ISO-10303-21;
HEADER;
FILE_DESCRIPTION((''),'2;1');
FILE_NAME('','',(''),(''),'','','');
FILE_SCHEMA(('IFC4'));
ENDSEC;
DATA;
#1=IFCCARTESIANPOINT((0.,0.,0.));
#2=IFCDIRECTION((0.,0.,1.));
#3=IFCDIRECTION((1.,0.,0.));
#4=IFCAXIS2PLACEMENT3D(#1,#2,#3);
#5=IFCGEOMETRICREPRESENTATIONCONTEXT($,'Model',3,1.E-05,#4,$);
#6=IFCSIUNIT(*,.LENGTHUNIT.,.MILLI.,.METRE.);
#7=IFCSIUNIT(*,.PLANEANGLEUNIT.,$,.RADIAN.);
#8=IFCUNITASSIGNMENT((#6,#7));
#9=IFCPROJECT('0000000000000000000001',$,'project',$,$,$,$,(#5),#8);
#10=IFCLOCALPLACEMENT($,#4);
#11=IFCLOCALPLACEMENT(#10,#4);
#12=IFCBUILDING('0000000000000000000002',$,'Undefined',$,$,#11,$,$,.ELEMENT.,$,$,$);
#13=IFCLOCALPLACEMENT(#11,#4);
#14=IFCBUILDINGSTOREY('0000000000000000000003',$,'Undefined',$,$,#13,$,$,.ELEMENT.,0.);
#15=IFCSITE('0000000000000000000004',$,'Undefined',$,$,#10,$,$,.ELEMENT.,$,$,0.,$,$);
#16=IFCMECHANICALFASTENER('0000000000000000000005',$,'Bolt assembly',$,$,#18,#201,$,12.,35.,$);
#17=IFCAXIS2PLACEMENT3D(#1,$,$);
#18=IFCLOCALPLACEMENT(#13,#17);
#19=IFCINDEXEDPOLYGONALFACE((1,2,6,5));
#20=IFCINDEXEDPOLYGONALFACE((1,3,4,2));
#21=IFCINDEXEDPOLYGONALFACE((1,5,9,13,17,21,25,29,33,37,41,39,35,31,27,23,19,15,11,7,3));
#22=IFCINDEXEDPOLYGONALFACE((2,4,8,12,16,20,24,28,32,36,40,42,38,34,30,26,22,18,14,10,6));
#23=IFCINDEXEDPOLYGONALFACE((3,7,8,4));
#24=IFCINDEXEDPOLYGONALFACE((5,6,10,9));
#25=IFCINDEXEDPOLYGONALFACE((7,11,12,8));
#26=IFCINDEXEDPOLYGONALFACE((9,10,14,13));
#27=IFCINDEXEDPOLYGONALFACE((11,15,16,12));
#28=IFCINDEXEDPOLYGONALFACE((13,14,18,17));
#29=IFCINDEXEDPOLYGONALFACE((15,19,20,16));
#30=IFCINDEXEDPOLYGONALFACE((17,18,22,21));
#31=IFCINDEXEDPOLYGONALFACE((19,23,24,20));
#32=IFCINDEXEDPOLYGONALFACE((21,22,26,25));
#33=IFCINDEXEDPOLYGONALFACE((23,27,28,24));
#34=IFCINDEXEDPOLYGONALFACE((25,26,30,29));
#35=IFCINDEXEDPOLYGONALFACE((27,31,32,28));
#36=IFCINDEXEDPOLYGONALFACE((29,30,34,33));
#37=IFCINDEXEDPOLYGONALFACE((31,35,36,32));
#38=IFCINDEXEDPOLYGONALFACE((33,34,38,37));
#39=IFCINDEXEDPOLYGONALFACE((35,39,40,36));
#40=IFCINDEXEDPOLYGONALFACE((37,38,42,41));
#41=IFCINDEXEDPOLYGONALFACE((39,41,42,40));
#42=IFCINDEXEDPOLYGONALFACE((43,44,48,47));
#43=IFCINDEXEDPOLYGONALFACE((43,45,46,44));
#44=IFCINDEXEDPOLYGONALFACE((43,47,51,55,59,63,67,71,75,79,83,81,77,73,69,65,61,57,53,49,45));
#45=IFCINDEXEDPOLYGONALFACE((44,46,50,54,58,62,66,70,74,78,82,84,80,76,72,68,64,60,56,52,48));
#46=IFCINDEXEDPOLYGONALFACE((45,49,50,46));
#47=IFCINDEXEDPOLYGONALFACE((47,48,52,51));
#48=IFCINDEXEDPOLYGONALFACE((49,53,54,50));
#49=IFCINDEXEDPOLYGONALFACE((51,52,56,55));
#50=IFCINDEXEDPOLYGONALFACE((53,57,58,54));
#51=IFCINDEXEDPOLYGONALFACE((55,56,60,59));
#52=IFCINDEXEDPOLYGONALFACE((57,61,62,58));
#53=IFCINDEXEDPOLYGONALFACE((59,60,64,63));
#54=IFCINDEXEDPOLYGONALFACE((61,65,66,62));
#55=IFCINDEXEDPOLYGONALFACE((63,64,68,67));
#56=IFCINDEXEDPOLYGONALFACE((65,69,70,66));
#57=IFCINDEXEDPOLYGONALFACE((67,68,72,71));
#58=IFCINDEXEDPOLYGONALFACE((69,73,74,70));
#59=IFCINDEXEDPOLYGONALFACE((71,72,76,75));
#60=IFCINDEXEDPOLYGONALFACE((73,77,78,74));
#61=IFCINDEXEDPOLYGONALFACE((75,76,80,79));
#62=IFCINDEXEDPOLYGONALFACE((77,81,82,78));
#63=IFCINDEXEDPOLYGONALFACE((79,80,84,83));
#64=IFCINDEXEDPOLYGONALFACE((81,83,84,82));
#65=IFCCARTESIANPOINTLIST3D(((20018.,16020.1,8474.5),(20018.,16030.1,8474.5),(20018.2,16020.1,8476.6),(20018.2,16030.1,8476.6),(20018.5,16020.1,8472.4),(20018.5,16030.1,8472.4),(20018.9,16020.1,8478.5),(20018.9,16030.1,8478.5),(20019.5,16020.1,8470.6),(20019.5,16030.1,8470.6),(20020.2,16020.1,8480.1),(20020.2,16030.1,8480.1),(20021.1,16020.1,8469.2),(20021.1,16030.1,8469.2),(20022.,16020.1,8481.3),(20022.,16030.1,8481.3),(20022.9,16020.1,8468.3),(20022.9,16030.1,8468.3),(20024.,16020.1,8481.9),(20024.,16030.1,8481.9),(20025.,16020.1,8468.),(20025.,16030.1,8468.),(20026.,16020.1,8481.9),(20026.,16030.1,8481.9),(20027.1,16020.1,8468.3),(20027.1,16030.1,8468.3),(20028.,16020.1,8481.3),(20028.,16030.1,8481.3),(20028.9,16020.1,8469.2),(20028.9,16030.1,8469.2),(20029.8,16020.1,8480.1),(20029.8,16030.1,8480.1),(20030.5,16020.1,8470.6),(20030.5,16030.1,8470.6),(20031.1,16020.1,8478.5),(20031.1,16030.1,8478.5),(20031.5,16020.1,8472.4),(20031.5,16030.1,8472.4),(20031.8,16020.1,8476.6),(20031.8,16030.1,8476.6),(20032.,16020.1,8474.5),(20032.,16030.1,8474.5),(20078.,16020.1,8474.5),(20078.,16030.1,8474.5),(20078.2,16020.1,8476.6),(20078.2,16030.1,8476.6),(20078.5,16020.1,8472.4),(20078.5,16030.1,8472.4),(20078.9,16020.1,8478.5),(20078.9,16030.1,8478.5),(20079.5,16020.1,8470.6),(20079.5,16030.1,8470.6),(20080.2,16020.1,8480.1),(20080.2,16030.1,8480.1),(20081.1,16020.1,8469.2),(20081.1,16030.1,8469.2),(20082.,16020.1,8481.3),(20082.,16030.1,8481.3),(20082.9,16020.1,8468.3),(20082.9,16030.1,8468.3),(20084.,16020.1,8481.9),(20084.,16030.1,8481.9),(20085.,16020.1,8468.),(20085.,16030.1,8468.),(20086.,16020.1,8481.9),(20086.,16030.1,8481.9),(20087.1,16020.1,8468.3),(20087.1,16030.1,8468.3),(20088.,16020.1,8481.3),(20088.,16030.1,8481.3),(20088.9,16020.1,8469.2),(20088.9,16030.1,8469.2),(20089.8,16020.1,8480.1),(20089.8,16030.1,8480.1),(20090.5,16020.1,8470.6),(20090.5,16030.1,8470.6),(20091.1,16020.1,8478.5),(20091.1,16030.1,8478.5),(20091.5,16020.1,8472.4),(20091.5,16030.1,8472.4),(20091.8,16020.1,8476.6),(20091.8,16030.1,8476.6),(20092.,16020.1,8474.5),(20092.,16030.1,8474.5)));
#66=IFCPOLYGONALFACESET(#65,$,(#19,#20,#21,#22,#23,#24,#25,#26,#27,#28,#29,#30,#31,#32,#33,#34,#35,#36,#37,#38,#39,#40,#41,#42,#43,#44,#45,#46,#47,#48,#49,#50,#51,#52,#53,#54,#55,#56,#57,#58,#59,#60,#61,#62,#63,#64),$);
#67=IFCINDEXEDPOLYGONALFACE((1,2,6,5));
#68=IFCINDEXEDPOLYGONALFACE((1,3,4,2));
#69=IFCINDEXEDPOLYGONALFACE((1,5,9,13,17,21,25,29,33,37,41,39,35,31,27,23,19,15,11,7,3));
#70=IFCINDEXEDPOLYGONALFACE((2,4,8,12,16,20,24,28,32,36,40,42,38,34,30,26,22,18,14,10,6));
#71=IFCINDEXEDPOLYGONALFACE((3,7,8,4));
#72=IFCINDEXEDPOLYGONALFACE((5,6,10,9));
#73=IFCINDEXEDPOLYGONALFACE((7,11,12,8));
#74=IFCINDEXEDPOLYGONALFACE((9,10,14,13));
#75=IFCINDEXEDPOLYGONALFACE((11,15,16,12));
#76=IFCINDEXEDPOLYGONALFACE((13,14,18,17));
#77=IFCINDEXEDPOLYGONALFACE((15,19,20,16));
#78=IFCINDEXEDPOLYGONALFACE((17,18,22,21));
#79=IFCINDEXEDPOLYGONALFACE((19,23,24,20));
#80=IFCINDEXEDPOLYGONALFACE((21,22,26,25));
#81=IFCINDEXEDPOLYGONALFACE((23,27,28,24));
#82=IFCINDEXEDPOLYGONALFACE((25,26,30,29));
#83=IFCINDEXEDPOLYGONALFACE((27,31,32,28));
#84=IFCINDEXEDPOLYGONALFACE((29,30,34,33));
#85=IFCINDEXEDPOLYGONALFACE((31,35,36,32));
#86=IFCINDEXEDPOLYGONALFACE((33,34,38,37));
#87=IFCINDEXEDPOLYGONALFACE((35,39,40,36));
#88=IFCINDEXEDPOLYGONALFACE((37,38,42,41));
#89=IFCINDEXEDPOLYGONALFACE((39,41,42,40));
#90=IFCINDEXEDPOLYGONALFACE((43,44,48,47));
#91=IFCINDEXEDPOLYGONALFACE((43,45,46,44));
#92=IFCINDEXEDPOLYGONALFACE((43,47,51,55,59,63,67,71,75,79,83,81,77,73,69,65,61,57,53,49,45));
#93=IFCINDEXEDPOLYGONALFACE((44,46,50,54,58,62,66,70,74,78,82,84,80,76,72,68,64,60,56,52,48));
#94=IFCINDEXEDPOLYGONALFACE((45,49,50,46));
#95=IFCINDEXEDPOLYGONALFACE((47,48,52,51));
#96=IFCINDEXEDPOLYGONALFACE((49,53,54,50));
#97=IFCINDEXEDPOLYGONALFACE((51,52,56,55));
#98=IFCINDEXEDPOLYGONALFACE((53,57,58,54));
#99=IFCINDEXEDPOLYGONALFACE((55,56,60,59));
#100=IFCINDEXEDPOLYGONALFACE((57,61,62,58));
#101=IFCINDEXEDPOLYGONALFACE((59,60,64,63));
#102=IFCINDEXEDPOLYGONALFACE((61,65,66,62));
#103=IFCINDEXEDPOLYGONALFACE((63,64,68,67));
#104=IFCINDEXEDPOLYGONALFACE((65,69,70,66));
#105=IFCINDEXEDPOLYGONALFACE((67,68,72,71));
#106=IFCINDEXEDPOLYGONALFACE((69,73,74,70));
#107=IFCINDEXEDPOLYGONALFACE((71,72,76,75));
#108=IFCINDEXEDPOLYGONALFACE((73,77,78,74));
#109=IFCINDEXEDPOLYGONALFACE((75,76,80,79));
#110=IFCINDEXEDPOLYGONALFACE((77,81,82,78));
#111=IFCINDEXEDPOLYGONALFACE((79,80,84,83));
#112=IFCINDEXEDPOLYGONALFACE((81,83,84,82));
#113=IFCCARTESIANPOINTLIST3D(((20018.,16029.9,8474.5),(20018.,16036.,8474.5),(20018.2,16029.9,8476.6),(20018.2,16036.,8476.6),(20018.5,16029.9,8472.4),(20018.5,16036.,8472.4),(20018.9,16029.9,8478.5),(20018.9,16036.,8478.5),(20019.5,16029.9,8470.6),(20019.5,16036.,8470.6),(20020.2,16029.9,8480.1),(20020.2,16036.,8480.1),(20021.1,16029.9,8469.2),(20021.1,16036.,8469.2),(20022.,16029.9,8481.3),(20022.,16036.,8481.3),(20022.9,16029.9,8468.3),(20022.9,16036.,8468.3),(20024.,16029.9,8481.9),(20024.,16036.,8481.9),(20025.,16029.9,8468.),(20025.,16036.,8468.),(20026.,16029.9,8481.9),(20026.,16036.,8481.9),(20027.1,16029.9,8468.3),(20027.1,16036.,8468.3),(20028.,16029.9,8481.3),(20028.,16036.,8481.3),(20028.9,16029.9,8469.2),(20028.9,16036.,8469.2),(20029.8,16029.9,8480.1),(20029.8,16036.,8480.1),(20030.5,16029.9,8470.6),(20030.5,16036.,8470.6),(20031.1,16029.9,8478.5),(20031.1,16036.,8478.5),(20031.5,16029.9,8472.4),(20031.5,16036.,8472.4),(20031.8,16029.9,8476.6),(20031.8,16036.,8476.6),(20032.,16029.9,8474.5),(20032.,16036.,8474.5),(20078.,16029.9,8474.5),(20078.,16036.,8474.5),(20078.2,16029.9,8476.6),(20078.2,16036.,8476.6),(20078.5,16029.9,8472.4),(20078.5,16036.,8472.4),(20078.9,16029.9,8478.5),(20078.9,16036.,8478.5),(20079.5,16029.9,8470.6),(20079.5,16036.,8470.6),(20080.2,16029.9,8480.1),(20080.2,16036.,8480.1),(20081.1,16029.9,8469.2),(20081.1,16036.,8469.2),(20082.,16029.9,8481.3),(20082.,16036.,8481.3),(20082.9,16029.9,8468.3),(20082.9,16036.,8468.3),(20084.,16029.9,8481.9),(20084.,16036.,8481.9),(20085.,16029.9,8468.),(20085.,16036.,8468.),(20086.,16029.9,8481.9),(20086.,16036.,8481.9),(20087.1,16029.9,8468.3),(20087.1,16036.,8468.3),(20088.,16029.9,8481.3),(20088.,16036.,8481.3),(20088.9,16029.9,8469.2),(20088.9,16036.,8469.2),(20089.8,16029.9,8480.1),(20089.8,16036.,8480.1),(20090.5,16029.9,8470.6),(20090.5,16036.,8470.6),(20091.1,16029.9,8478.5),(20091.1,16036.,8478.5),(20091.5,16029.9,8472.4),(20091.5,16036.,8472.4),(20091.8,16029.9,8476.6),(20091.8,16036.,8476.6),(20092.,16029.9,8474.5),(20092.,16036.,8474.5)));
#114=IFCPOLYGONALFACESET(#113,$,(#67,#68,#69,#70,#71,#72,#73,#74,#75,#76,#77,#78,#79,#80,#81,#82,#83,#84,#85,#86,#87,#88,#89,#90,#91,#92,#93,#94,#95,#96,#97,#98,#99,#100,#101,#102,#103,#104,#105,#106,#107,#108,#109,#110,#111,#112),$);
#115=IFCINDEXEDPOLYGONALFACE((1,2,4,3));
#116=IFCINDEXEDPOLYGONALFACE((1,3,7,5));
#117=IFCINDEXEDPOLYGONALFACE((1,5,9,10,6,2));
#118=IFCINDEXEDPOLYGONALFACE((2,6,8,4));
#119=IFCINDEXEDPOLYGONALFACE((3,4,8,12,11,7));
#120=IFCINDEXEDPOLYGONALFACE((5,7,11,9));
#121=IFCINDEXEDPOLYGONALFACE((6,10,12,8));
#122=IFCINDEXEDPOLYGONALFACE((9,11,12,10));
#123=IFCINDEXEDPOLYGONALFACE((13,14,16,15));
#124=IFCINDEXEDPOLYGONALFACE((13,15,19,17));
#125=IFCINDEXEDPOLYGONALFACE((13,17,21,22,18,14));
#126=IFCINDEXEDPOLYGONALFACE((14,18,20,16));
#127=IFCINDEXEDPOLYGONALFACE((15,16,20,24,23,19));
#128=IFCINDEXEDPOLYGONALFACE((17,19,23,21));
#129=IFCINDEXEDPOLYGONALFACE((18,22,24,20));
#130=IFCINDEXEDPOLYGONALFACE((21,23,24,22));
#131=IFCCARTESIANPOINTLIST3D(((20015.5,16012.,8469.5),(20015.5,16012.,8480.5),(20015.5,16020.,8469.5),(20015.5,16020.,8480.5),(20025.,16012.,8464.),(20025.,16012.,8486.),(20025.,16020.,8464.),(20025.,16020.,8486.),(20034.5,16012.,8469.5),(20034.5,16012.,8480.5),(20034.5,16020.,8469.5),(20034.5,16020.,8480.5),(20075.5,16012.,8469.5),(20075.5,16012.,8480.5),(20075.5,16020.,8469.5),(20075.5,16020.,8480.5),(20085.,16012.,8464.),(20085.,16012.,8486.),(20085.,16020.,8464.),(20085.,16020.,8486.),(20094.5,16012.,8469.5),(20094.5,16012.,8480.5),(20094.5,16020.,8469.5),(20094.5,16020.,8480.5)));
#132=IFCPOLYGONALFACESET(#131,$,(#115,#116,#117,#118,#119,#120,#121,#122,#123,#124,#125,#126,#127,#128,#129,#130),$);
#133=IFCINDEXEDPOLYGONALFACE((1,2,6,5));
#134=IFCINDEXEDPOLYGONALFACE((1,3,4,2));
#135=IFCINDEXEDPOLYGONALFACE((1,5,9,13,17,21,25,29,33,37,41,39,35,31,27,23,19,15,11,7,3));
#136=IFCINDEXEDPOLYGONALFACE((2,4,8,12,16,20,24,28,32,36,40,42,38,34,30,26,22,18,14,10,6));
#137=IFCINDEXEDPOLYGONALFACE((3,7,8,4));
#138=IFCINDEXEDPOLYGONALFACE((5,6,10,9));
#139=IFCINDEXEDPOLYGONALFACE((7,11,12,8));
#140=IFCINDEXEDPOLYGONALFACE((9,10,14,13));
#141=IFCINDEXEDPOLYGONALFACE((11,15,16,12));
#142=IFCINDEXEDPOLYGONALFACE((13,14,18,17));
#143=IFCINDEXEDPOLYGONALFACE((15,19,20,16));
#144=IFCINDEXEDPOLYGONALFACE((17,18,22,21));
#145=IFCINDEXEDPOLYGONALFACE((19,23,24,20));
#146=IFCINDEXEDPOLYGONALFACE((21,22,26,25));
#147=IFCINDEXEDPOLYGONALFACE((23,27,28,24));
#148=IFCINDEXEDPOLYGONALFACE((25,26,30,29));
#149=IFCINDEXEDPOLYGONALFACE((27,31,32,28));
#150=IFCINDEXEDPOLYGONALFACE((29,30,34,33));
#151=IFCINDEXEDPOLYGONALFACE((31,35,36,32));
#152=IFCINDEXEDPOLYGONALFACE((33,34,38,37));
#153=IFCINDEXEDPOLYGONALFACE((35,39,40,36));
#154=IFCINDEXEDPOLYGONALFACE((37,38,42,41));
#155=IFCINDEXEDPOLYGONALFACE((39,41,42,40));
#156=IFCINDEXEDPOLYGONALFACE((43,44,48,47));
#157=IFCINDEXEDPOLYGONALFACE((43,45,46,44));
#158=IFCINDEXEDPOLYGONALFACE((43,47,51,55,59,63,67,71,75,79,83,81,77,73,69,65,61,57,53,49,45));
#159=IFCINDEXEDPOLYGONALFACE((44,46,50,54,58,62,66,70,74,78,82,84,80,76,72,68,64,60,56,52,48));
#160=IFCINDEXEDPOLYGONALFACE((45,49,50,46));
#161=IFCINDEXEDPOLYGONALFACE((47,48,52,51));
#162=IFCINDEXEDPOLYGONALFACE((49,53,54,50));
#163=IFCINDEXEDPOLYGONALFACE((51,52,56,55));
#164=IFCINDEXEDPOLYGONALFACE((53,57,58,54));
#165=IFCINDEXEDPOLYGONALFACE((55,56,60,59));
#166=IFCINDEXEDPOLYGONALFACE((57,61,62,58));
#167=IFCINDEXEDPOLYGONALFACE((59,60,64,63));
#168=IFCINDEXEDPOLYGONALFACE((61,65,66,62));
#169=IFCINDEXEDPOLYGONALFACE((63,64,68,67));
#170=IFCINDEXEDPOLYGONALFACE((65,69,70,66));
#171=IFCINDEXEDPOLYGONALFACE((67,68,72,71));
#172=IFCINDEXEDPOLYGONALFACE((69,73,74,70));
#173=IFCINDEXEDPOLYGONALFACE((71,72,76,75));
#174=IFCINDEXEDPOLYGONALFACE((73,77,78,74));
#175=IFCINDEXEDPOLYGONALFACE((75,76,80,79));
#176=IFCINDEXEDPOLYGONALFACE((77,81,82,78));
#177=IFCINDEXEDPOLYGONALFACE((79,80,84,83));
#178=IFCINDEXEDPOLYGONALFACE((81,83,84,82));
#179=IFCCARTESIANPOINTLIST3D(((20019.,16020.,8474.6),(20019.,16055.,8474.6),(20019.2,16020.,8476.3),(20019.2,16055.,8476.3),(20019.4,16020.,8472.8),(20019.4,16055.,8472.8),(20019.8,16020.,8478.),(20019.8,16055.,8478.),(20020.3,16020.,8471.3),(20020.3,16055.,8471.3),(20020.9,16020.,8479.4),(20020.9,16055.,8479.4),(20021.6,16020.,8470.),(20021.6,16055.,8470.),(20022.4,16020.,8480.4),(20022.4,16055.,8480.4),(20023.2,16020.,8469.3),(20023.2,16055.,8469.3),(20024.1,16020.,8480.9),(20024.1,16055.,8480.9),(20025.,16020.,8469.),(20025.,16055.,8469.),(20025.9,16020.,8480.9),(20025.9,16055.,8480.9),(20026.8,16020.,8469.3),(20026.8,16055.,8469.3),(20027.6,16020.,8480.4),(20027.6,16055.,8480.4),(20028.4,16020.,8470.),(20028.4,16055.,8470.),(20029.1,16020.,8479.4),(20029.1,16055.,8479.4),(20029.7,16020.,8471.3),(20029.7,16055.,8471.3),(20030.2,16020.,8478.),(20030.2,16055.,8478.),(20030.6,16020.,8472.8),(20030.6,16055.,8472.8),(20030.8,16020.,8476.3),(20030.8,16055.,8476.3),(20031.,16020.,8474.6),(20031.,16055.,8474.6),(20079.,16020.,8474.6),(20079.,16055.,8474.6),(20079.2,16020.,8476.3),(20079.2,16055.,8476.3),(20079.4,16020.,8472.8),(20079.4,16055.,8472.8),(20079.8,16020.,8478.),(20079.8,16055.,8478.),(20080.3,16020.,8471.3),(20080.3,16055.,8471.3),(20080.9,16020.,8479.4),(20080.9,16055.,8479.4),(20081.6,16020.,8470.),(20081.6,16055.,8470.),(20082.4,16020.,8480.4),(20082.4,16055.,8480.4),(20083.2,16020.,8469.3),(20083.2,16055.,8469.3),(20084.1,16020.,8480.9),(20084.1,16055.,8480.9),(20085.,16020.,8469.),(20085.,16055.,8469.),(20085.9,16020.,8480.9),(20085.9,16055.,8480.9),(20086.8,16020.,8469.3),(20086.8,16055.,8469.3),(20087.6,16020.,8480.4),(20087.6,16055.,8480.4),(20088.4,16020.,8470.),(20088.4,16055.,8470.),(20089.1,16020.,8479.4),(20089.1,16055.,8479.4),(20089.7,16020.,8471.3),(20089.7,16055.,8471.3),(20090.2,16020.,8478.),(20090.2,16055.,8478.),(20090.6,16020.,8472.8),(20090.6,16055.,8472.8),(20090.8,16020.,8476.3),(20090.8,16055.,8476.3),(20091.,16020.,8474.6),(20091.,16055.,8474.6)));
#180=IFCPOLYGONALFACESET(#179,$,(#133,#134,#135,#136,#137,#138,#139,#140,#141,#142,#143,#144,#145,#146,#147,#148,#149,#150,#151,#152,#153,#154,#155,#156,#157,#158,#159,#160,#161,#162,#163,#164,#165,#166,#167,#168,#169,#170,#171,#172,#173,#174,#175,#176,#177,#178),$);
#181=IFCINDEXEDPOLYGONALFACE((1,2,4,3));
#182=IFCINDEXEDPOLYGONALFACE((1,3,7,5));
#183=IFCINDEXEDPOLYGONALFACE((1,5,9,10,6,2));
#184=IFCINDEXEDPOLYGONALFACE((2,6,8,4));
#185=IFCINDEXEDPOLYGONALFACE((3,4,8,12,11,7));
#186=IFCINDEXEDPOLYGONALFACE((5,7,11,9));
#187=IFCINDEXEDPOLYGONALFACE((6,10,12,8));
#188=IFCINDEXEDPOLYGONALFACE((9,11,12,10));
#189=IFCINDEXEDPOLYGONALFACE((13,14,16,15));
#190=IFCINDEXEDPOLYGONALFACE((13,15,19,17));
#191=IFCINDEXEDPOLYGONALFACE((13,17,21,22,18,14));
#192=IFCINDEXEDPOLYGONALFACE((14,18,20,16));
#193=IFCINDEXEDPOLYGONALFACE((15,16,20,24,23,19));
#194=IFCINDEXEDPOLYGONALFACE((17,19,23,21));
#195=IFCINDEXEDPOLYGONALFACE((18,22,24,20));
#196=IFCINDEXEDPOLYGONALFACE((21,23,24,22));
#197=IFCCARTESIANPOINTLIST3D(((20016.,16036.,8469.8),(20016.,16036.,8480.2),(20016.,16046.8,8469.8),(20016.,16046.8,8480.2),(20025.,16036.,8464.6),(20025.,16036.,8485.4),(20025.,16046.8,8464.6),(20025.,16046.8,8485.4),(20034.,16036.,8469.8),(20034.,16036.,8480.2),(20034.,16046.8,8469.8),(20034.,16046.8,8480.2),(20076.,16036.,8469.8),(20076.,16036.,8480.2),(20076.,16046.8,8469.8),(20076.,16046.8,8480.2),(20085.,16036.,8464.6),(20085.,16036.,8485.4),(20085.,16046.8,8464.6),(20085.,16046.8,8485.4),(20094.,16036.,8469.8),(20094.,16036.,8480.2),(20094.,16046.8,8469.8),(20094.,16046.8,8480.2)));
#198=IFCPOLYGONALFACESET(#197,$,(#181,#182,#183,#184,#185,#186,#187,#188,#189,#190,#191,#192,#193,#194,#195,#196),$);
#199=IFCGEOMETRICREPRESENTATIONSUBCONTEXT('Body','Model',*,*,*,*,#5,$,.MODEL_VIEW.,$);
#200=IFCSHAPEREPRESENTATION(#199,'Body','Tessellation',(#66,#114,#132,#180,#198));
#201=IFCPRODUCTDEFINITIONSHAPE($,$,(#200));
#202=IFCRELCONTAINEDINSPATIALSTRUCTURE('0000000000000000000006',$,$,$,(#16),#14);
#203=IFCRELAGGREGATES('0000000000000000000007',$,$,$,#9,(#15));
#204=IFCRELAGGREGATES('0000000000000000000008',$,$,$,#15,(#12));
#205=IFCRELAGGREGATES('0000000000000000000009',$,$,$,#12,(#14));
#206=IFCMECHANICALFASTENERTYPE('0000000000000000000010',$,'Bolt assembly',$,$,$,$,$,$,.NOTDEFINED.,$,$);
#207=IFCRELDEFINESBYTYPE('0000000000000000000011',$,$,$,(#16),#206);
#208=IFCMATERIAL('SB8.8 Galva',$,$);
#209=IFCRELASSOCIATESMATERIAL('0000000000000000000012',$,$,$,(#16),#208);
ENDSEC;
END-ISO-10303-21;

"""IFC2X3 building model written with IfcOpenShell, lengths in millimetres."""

from ifc_helpers import new_model, si_unit, frame, origin_with_axes, origin_2d_with_axis, place, context, subcontext, project, spatial, polyline, circle, outline, extrude, source, transform, mapped, material, type_object, element, save


model = new_model("IFC2X3")

# Units and contexts
model_context = context("Model", 3, precision=1e-05, world=origin_with_axes())
body_context = subcontext(model_context, "Body", "Model", "MODEL_VIEW")
ifc_project = project(units=[si_unit("LENGTHUNIT", "METRE", prefix="MILLI"), si_unit("PLANEANGLEUNIT", "RADIAN")], contexts=[model_context])

# Site, building, storey
site_placement = place(None, origin_with_axes())
site = spatial("IfcSite", under=ifc_project, at=site_placement, Name="Undefined", CompositionType="ELEMENT", RefElevation=0.0)
building_placement = place(site_placement, origin_with_axes())
building = spatial("IfcBuilding", under=site, at=building_placement, Name="Undefined", CompositionType="ELEMENT")
storey_placement = place(building_placement, origin_with_axes())
storey = spatial("IfcBuildingStorey", under=building, at=storey_placement, Name="Undefined", CompositionType="ELEMENT", Elevation=0.0)

# Mechanical fastener
mechanical_fastener_type = type_object("IfcMechanicalFastenerType", Name="Bolt assembly")
ifc_material_1 = material(Name="SB8.8 Galva")
shared_shape_1 = source(origin_with_axes(), body_context, "Body", "SweptSolid", [
    extrude(circle(Radius=7.0, at=origin_2d_with_axis()), frame((0.0, -9.9, 0.0), z_axis=(0.0, 1.0, 0.0), x_axis=(1.0, 0.0, 0.0)), (0.0, 0.0, 1.0), 10.0),
    extrude(circle(Radius=7.0, at=origin_2d_with_axis()), frame((0.0, -0.1, 0.0), z_axis=(0.0, 1.0, 0.0), x_axis=(1.0, 0.0, 0.0)), (0.0, 0.0, 1.0), 6.1),
    extrude(outline(polyline([(11.0, 0.0), (5.5, 9.5), (-5.5, 9.5), (-11.0, 0.0), (-5.5, -9.5), (5.5, -9.5), (11.0, 0.0)])), frame((0.0, -18.0, 0.0), z_axis=(0.0, 1.0, 0.0), x_axis=(1.0, 0.0, 0.0)), (0.0, 0.0, 1.0), 8.0),
    extrude(circle(Radius=6.0, at=origin_2d_with_axis()), frame((0.0, -10.0, 0.0), z_axis=(0.0, 1.0, 0.0), x_axis=(1.0, 0.0, 0.0)), (0.0, 0.0, 1.0), 35.0),
    extrude(outline(polyline([(10.4, 0.0), (5.2, 9.0), (-5.2, 9.0), (-10.4, 0.0), (-5.2, -9.0), (5.2, -9.0), (10.4, 0.0)])), frame((0.0, 6.0, 0.0), z_axis=(0.0, 1.0, 0.0), x_axis=(1.0, 0.0, 0.0)), (0.0, 0.0, 1.0), 10.8),
])
mechanical_fastener_1_placement = place(storey_placement, frame((20055.0, 16030.0, 8475.0), z_axis=(1.0, 0.0, 0.0), x_axis=(0.0, 0.0, -1.0)))
element("IfcMechanicalFastener", 1, at=mechanical_fastener_1_placement, inside=storey, type_object=mechanical_fastener_type, material=ifc_material_1, Name="Bolt assembly", NominalDiameter=12.0, NominalLength=35.0, context=body_context, shape_type="MappedRepresentation", body=[
    mapped(shared_shape_1, transform((0.0, 0.0, -30.0))),
    mapped(shared_shape_1, transform((0.0, 0.0, 30.0))),
])

save(model, "model.ifc")
